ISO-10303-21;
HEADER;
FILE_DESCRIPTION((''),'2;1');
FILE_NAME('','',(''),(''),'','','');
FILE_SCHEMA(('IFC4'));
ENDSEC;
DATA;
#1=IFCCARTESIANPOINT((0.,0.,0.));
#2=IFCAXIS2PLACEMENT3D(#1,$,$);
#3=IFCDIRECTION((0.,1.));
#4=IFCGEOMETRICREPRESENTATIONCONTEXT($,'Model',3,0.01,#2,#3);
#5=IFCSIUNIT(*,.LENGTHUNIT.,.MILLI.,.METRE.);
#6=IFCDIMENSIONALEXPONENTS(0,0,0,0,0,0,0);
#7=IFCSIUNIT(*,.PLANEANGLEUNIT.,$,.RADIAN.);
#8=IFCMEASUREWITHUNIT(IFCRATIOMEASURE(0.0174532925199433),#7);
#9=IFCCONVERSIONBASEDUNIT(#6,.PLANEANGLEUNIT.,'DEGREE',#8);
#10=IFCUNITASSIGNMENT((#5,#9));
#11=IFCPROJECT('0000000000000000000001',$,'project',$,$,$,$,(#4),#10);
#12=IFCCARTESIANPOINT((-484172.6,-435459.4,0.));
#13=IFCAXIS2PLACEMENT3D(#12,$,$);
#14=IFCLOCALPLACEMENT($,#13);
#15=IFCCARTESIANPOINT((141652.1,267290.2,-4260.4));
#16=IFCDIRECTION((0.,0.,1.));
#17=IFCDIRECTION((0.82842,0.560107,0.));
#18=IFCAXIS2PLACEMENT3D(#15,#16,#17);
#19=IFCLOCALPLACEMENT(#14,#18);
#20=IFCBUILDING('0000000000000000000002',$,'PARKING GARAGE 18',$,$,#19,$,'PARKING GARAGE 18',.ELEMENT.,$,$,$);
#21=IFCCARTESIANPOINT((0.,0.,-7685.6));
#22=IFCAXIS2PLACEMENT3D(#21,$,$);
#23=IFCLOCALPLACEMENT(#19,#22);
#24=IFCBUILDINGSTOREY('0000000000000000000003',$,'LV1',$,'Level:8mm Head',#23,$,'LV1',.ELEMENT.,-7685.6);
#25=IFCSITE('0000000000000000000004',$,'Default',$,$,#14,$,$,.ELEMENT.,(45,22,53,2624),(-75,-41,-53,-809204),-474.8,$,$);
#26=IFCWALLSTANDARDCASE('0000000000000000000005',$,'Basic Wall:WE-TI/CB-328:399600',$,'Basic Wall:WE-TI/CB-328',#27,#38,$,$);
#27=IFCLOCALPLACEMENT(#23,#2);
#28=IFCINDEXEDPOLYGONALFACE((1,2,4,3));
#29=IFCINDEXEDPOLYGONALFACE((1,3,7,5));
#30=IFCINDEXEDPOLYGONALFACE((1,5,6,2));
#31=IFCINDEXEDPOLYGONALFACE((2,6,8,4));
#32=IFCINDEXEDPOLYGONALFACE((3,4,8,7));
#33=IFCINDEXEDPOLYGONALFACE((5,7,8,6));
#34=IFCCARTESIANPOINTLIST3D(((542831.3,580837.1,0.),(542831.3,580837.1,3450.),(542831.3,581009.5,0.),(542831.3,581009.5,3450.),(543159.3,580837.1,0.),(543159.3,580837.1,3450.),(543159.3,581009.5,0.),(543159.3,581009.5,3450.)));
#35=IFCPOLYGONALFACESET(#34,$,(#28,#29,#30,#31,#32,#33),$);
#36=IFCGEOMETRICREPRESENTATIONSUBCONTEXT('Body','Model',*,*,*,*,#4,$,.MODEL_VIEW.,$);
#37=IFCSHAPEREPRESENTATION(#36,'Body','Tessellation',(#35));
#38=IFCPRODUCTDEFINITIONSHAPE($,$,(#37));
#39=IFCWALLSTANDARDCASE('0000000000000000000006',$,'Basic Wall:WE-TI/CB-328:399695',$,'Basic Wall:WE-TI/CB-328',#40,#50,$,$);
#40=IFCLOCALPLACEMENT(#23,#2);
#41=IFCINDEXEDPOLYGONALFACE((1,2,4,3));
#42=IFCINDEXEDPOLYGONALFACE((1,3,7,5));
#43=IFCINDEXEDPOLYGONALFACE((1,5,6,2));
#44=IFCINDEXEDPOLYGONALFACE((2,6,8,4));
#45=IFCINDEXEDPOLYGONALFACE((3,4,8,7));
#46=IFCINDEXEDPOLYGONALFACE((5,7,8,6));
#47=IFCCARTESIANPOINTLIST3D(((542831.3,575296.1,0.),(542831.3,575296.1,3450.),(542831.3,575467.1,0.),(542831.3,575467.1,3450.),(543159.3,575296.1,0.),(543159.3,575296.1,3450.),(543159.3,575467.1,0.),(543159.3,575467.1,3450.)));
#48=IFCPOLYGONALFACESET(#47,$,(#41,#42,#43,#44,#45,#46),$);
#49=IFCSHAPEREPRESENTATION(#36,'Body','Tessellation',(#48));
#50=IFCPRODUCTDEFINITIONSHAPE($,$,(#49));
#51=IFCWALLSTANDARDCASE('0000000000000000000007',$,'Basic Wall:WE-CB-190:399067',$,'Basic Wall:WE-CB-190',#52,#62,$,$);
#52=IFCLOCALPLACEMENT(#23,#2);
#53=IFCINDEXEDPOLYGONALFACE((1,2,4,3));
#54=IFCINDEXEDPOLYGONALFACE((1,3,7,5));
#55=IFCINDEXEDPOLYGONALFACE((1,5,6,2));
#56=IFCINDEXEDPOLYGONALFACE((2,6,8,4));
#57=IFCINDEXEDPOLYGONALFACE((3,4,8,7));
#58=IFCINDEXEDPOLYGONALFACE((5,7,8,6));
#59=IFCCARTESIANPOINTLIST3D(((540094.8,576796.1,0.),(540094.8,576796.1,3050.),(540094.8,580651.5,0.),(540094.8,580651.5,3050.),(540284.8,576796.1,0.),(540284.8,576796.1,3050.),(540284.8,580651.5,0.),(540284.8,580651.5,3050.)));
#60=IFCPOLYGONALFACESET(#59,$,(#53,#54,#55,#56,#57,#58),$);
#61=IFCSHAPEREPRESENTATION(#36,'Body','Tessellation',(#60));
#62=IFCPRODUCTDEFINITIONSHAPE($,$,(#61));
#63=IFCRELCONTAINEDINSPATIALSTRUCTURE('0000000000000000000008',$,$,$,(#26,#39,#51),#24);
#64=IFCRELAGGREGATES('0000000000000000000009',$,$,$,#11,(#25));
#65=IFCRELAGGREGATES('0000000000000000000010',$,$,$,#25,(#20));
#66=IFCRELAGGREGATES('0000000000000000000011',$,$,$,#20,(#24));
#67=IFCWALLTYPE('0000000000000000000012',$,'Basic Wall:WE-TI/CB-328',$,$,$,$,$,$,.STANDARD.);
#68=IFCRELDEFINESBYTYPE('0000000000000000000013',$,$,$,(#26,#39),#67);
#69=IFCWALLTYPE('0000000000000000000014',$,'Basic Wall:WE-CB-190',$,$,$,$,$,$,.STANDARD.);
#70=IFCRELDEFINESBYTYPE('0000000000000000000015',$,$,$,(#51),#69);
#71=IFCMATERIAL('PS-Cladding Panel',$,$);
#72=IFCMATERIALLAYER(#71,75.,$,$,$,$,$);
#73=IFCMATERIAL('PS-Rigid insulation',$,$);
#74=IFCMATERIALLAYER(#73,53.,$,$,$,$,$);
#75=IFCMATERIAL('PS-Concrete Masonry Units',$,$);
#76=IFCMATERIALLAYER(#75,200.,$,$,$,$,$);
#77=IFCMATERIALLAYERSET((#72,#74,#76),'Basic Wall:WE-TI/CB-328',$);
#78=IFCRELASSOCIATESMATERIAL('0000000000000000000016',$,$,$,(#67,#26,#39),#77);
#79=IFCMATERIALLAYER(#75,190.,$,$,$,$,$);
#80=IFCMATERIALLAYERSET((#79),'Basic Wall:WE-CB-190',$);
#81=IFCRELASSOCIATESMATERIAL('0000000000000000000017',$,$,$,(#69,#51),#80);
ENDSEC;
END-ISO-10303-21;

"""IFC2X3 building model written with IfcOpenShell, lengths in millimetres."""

from ifc_helpers import new_model, entity, si_unit, converted_unit, direction, frame, frame_2d, origin, place, context, subcontext, project, spatial, rectangle, extrude, material, layer, layer_set, layer_usage, type_object, element, save


model = new_model("IFC2X3")

# Units and contexts
model_context = context("Model", 3, precision=0.01, world=origin(), true_north=direction((0.0, 1.0)))
body_context = subcontext(model_context, "Body", "Model", "MODEL_VIEW")
ifc_project = project(units=[si_unit("LENGTHUNIT", "METRE", prefix="MILLI"), converted_unit("PLANEANGLEUNIT", "DEGREE", entity("IfcRatioMeasure", 0.0174532925199433), si_unit("PLANEANGLEUNIT", "RADIAN"), dimensions=[0, 0, 0, 0, 0, 0, 0])], contexts=[model_context])

# Site, building, storey
site_placement = place(None, frame((-484172.6, -435459.4, 0.0)))
site = spatial("IfcSite", under=ifc_project, at=site_placement, Name="Default", CompositionType="ELEMENT", RefLatitude=(45, 22, 53, 2624), RefLongitude=(-75, -41, -53, -809204), RefElevation=-474.8)
building_placement = place(site_placement, frame((141652.1, 267290.2, -4260.4), z_axis=(0.0, 0.0, 1.0), x_axis=(0.82842, 0.560107, 0.0)))
building = spatial("IfcBuilding", under=site, at=building_placement, Name="PARKING GARAGE 18", LongName="PARKING GARAGE 18", CompositionType="ELEMENT")
storey_placement = place(building_placement, frame((0.0, 0.0, -7685.6)))
storey = spatial("IfcBuildingStorey", under=building, at=storey_placement, Name="LV1", ObjectType="Level:8mm Head", LongName="LV1", CompositionType="ELEMENT", Elevation=-7685.6)

# Walls
ifc_material_1 = material(Name="PS-Cladding Panel")
ifc_layer_1 = layer(ifc_material_1, 75.0)
ifc_material_2 = material(Name="PS-Rigid insulation")
ifc_layer_2 = layer(ifc_material_2, 53.0)
ifc_material_3 = material(Name="PS-Concrete Masonry Units")
ifc_layer_3 = layer(ifc_material_3, 200.0)
ifc_layer_set_1 = layer_set([ifc_layer_1, ifc_layer_2, ifc_layer_3], Name="Basic Wall:WE-TI/CB-328")
wall_type_1 = type_object("IfcWallType", Name="Basic Wall:WE-TI/CB-328", PredefinedType="STANDARD", material=ifc_layer_set_1)
ifc_layer_usage_1 = layer_usage(ifc_layer_set_1, "AXIS2", "POSITIVE", -164.0)
wall_1_placement = place(storey_placement, frame((542995.3, 580837.1, 0.0), z_axis=(0.0, 0.0, 1.0), x_axis=(0.0, 1.0, 0.0)))
element("IfcWallStandardCase", 1, at=wall_1_placement, inside=storey, type_object=wall_type_1, material=ifc_layer_usage_1, Name="Basic Wall:WE-TI/CB-328:399600", ObjectType="Basic Wall:WE-TI/CB-328", context=body_context, shape_type="SweptSolid", body=[
    extrude(rectangle(XDim=172.4, YDim=328.0, at=frame_2d((86.2, 0.0), x_axis=(-1.0, 0.0))), origin(), (0.0, 0.0, 1.0), 3450.0),
])
ifc_layer_usage_2 = layer_usage(ifc_layer_set_1, "AXIS2", "POSITIVE", -164.0)
wall_2_placement = place(storey_placement, frame((542995.3, 575296.1, 0.0), z_axis=(0.0, 0.0, 1.0), x_axis=(0.0, 1.0, 0.0)))
element("IfcWallStandardCase", 2, at=wall_2_placement, inside=storey, type_object=wall_type_1, material=ifc_layer_usage_2, Name="Basic Wall:WE-TI/CB-328:399695", ObjectType="Basic Wall:WE-TI/CB-328", context=body_context, shape_type="SweptSolid", body=[
    extrude(rectangle(XDim=171.0, YDim=328.0, at=frame_2d((85.5, 0.0), x_axis=(-1.0, 0.0))), origin(), (0.0, 0.0, 1.0), 3450.0),
])
ifc_layer_4 = layer(ifc_material_3, 190.0)
ifc_layer_set_2 = layer_set([ifc_layer_4], Name="Basic Wall:WE-CB-190")
ifc_layer_usage_3 = layer_usage(ifc_layer_set_2, "AXIS2", "NEGATIVE", 95.0)
wall_type_2 = type_object("IfcWallType", Name="Basic Wall:WE-CB-190", PredefinedType="STANDARD", material=ifc_layer_set_2)
wall_3_placement = place(storey_placement, frame((540189.8, 580651.5, 0.0), z_axis=(0.0, 0.0, 1.0), x_axis=(0.0, -1.0, 0.0)))
element("IfcWallStandardCase", 3, at=wall_3_placement, inside=storey, type_object=wall_type_2, material=ifc_layer_usage_3, Name="Basic Wall:WE-CB-190:399067", ObjectType="Basic Wall:WE-CB-190", context=body_context, shape_type="SweptSolid", body=[
    extrude(rectangle(XDim=3855.5, YDim=190.0, at=frame_2d((1927.7, 0.0), x_axis=(-1.0, 0.0))), origin(), (0.0, 0.0, 1.0), 3050.0),
])

save(model, "model.ifc")
